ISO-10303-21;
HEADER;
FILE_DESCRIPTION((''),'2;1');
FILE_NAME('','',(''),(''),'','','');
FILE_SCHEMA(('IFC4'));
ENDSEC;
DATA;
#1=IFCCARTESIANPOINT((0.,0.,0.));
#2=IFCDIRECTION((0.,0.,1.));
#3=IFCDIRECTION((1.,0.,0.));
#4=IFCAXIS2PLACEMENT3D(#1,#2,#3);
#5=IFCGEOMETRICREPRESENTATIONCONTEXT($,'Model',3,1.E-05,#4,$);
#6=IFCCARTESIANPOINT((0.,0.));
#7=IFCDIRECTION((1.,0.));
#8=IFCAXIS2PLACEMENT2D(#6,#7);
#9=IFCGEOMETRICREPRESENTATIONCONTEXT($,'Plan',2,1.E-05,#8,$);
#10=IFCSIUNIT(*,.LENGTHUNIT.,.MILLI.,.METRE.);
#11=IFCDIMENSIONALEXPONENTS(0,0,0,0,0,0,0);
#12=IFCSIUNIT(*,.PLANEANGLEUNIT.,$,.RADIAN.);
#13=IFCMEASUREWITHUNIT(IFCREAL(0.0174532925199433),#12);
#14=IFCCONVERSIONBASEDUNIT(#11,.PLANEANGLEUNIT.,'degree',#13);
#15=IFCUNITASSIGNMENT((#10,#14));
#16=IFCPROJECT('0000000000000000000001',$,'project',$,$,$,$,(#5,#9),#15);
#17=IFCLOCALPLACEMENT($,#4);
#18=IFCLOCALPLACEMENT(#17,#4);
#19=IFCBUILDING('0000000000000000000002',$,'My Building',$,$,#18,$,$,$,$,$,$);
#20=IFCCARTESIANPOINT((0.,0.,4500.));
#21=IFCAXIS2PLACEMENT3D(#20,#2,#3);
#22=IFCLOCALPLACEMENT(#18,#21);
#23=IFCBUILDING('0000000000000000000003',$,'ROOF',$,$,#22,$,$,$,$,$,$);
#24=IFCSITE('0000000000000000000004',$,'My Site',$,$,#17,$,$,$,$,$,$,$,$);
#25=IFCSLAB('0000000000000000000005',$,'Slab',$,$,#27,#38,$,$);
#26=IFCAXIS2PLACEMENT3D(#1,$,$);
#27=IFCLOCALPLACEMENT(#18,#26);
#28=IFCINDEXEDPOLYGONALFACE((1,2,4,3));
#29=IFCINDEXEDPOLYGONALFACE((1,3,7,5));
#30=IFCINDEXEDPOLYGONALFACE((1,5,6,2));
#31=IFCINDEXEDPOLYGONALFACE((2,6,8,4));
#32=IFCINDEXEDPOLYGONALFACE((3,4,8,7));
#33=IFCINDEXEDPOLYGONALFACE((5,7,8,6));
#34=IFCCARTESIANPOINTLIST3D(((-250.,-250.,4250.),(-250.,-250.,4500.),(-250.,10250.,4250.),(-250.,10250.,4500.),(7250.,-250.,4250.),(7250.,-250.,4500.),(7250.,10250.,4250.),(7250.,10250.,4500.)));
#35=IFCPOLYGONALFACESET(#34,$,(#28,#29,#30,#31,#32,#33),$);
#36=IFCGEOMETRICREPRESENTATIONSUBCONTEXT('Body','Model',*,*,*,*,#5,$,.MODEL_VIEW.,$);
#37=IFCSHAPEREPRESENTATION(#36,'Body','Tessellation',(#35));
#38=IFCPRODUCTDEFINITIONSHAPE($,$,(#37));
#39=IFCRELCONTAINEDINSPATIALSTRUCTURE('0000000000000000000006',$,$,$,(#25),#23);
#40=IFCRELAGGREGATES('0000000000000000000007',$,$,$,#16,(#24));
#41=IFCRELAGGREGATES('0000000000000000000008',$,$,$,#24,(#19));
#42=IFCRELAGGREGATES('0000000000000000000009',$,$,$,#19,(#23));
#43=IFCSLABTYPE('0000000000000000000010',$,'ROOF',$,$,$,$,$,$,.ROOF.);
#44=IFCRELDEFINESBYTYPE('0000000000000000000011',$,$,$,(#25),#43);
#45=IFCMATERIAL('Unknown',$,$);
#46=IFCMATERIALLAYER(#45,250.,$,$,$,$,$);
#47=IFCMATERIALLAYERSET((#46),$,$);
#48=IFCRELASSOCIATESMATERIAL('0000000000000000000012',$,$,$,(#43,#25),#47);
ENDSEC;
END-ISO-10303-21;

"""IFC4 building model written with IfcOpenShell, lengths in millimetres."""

from ifc_helpers import new_model, entity, si_unit, converted_unit, frame, origin_with_axes, origin_2d_with_axis, place, context, subcontext, project, spatial, indexed_curve, outline, extrude, material, layer, layer_set, layer_usage, type_object, element, save


model = new_model("IFC4")

# Units and contexts
model_context = context("Model", 3, precision=1e-05, world=origin_with_axes())
plan_context = context("Plan", 2, precision=1e-05, world=origin_2d_with_axis())
body_context = subcontext(model_context, "Body", "Model", "MODEL_VIEW")
ifc_project = project(units=[si_unit("LENGTHUNIT", "METRE", prefix="MILLI"), converted_unit("PLANEANGLEUNIT", "degree", entity("IfcReal", 0.0174532925199433), si_unit("PLANEANGLEUNIT", "RADIAN"), dimensions=[0, 0, 0, 0, 0, 0, 0])], contexts=[model_context, plan_context])

# Site, buildings
site_placement = place(None, origin_with_axes())
site = spatial("IfcSite", under=ifc_project, at=site_placement, Name="My Site")
building_1_placement = place(site_placement, origin_with_axes())
building_1 = spatial("IfcBuilding", under=site, at=building_1_placement, Name="My Building")
building_2_placement = place(building_1_placement, frame((0.0, 0.0, 4500.0), z_axis=(0.0, 0.0, 1.0), x_axis=(1.0, 0.0, 0.0)))
building_2 = spatial("IfcBuilding", under=building_1, at=building_2_placement, Name="ROOF")

# Slab
ifc_material = material(Name="Unknown")
ifc_layer = layer(ifc_material, 250.0)
ifc_layer_set = layer_set([ifc_layer])
ifc_layer_usage = layer_usage(ifc_layer_set, "AXIS3", "POSITIVE", -250.0)
slab_type = type_object("IfcSlabType", Name="ROOF", PredefinedType="ROOF", material=ifc_layer_set)
slab_placement = place(building_2_placement, frame((-250.0, 10250.0, 0.0), z_axis=(0.0, 0.0, 1.0), x_axis=(1.0, 0.0, 0.0)))
element("IfcSlab", 1, at=slab_placement, inside=building_2, type_object=slab_type, material=ifc_layer_usage, Name="Slab", context=body_context, shape_type="SweptSolid", body=[
    extrude(outline(indexed_curve([(0.0, 0.0), (7500.0, 0.0), (7500.0, -10500.0), (0.0, -10500.0), (0.0, 0.0)])), frame((0.0, 0.0, -250.0), z_axis=(0.0, 0.0, 1.0), x_axis=(1.0, 0.0, 0.0)), (0.0, 0.0, 1.0), 250.0),
])

save(model, "model.ifc")
